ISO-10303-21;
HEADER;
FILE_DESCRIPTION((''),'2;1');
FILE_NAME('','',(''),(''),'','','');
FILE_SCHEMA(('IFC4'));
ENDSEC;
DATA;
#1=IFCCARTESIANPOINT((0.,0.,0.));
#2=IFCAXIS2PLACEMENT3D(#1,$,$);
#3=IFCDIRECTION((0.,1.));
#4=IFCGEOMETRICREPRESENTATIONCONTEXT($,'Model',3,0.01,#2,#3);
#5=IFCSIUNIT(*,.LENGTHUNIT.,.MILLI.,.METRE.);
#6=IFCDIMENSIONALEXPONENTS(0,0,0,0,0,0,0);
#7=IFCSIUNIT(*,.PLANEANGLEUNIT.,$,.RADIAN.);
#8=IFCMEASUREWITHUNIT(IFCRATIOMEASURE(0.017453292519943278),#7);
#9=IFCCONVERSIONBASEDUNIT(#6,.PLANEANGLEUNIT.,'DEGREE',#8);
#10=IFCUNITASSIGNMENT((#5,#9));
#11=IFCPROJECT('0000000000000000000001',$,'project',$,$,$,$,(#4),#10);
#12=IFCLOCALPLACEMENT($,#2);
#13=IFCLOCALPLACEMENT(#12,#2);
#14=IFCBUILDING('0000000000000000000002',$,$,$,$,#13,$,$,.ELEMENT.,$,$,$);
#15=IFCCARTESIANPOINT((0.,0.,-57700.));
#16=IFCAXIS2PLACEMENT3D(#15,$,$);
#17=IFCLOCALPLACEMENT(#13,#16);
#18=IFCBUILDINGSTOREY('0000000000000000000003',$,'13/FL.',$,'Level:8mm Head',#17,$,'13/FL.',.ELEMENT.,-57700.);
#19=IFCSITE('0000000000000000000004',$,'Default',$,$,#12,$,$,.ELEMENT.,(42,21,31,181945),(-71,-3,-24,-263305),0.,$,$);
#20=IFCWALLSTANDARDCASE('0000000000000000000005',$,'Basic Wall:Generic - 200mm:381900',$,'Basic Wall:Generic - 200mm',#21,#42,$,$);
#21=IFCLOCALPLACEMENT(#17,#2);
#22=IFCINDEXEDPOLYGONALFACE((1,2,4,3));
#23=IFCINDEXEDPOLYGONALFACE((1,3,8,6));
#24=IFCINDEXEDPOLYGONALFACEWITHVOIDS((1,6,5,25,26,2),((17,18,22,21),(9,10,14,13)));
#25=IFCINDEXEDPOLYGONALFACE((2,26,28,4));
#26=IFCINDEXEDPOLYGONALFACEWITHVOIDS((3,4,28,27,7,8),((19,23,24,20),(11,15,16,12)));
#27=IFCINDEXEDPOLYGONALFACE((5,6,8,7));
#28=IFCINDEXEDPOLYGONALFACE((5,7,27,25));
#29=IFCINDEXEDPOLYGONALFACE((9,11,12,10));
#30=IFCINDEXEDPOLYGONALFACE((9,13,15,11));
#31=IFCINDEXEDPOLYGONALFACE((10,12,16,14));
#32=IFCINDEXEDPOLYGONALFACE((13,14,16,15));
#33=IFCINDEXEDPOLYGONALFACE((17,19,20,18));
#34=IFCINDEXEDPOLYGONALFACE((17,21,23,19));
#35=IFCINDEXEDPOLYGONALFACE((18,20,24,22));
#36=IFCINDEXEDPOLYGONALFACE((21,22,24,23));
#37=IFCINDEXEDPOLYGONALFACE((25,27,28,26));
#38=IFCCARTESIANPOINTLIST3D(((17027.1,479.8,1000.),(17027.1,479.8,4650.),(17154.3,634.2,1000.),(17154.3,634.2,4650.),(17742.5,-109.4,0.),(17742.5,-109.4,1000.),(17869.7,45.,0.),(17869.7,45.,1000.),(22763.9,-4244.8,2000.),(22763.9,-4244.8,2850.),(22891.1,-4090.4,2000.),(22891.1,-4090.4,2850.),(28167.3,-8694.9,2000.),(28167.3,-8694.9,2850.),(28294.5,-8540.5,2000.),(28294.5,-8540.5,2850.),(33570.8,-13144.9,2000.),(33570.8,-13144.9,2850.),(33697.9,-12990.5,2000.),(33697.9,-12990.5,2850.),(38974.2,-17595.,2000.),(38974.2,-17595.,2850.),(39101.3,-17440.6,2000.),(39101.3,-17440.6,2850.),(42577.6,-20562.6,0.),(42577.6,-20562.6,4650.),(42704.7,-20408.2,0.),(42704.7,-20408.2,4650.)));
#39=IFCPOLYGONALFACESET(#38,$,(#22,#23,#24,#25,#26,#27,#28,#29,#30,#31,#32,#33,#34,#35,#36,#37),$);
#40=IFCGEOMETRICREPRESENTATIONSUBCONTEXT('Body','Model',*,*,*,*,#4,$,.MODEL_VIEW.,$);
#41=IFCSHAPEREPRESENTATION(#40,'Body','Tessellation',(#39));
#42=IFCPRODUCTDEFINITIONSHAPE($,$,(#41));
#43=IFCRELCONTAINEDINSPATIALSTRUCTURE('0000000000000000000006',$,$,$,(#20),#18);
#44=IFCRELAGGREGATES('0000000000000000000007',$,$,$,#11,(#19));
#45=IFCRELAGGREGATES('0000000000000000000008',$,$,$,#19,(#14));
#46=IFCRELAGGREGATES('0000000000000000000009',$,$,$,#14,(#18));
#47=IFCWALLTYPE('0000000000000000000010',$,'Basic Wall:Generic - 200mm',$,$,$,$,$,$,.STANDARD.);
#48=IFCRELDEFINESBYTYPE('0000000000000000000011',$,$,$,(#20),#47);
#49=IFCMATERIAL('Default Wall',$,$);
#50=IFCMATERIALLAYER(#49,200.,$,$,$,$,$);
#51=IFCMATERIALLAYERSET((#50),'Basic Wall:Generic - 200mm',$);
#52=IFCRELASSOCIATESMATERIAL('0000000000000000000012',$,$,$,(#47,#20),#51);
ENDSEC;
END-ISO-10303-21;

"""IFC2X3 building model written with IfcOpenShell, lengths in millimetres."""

from ifc_helpers import new_model, entity, si_unit, converted_unit, direction, frame, frame_2d, origin, origin_2d_with_axis, place, context, subcontext, project, spatial, rectangle, extrude, material, layer, layer_set, layer_usage, type_object, element, save


model = new_model("IFC2X3")

# Units and contexts
model_context = context("Model", 3, precision=0.01, world=origin(), true_north=direction((0.0, 1.0)))
body_context = subcontext(model_context, "Body", "Model", "MODEL_VIEW")
ifc_project = project(units=[si_unit("LENGTHUNIT", "METRE", prefix="MILLI"), converted_unit("PLANEANGLEUNIT", "DEGREE", entity("IfcRatioMeasure", 0.017453292519943278), si_unit("PLANEANGLEUNIT", "RADIAN"), dimensions=[0, 0, 0, 0, 0, 0, 0])], contexts=[model_context])

# Site, building, storey
site_placement = place(None, origin())
site = spatial("IfcSite", under=ifc_project, at=site_placement, Name="Default", CompositionType="ELEMENT", RefLatitude=(42, 21, 31, 181945), RefLongitude=(-71, -3, -24, -263305), RefElevation=0.0)
building_placement = place(site_placement, origin())
building = spatial("IfcBuilding", under=site, at=building_placement, CompositionType="ELEMENT")
storey_placement = place(building_placement, frame((0.0, 0.0, -57700.0)))
storey = spatial("IfcBuildingStorey", under=building, at=storey_placement, Name="13/FL.", ObjectType="Level:8mm Head", LongName="13/FL.", CompositionType="ELEMENT", Elevation=-57700.0)

# Wall, openings
ifc_material_1 = material(Name="Default Wall")
ifc_layer = layer(ifc_material_1, 200.0)
ifc_layer_set = layer_set([ifc_layer], Name="Basic Wall:Generic - 200mm")
ifc_layer_usage = layer_usage(ifc_layer_set, "AXIS2", "NEGATIVE", 100.0)
wall_type = type_object("IfcWallType", Name="Basic Wall:Generic - 200mm", PredefinedType="STANDARD", material=ifc_layer_set)
wall_1_placement = place(storey_placement, frame((42641.2, -20485.4, 0.0), z_axis=(0.0, 0.0, 1.0), x_axis=(-0.771917, 0.635723, 0.0)))
wall_1 = element("IfcWallStandardCase", 1, at=wall_1_placement, inside=storey, type_object=wall_type, material=ifc_layer_usage, Name="Basic Wall:Generic - 200mm:381900", ObjectType="Basic Wall:Generic - 200mm", context=body_context, shape_type="SweptSolid", body=[
    extrude(rectangle(XDim=33100.0, YDim=200.0, at=frame_2d((16550.0, 0.0), x_axis=(-1.0, 0.0))), origin(), (0.0, 0.0, 1.0), 4650.0),
])
opening_1_placement = place(wall_1_placement, origin())
element("IfcOpeningElement", 2, at=opening_1_placement, cuts=wall_1, ObjectType="Opening", context=body_context, shape_type="SweptSolid", body=[
    extrude(rectangle(XDim=850.0, YDim=7000.0, at=origin_2d_with_axis()), frame((8168.1, -100.0, 2425.0), z_axis=(0.0, 1.0, 0.0), x_axis=(0.0, 0.0, -1.0)), (0.0, 0.0, 1.0), 200.0),
])
opening_2_placement = place(wall_1_placement, origin())
element("IfcOpeningElement", 3, at=opening_2_placement, cuts=wall_1, ObjectType="Opening", context=body_context, shape_type="SweptSolid", body=[
    extrude(rectangle(XDim=850.0, YDim=7000.0, at=frame_2d((0.0, 0.0), x_axis=(1.0, 0.0))), frame((22168.1, -100.0, 2425.0), z_axis=(0.0, 1.0, 0.0), x_axis=(0.0, 0.0, -1.0)), (0.0, 0.0, 1.0), 200.0),
])
opening_3_placement = place(wall_1_placement, frame((45938.5, 11294.9, 0.0), z_axis=(0.0, 0.0, 1.0), x_axis=(-0.771917, -0.635723, 0.0)))
element("IfcOpeningElement", 4, at=opening_3_placement, cuts=wall_1, ObjectType="Opening", context=body_context, shape_type="SweptSolid", body=[
    extrude(rectangle(XDim=1000.0, YDim=1010.1, at=frame_2d((0.0, 0.0), x_axis=(1.0, 0.0))), frame((17487.9, 375.9, 500.0), z_axis=(-0.635723, -0.771917, 0.0), x_axis=(0.0, 0.0, -1.0)), (0.0, 0.0, 1.0), 1012.7),
])

save(model, "model.ifc")
